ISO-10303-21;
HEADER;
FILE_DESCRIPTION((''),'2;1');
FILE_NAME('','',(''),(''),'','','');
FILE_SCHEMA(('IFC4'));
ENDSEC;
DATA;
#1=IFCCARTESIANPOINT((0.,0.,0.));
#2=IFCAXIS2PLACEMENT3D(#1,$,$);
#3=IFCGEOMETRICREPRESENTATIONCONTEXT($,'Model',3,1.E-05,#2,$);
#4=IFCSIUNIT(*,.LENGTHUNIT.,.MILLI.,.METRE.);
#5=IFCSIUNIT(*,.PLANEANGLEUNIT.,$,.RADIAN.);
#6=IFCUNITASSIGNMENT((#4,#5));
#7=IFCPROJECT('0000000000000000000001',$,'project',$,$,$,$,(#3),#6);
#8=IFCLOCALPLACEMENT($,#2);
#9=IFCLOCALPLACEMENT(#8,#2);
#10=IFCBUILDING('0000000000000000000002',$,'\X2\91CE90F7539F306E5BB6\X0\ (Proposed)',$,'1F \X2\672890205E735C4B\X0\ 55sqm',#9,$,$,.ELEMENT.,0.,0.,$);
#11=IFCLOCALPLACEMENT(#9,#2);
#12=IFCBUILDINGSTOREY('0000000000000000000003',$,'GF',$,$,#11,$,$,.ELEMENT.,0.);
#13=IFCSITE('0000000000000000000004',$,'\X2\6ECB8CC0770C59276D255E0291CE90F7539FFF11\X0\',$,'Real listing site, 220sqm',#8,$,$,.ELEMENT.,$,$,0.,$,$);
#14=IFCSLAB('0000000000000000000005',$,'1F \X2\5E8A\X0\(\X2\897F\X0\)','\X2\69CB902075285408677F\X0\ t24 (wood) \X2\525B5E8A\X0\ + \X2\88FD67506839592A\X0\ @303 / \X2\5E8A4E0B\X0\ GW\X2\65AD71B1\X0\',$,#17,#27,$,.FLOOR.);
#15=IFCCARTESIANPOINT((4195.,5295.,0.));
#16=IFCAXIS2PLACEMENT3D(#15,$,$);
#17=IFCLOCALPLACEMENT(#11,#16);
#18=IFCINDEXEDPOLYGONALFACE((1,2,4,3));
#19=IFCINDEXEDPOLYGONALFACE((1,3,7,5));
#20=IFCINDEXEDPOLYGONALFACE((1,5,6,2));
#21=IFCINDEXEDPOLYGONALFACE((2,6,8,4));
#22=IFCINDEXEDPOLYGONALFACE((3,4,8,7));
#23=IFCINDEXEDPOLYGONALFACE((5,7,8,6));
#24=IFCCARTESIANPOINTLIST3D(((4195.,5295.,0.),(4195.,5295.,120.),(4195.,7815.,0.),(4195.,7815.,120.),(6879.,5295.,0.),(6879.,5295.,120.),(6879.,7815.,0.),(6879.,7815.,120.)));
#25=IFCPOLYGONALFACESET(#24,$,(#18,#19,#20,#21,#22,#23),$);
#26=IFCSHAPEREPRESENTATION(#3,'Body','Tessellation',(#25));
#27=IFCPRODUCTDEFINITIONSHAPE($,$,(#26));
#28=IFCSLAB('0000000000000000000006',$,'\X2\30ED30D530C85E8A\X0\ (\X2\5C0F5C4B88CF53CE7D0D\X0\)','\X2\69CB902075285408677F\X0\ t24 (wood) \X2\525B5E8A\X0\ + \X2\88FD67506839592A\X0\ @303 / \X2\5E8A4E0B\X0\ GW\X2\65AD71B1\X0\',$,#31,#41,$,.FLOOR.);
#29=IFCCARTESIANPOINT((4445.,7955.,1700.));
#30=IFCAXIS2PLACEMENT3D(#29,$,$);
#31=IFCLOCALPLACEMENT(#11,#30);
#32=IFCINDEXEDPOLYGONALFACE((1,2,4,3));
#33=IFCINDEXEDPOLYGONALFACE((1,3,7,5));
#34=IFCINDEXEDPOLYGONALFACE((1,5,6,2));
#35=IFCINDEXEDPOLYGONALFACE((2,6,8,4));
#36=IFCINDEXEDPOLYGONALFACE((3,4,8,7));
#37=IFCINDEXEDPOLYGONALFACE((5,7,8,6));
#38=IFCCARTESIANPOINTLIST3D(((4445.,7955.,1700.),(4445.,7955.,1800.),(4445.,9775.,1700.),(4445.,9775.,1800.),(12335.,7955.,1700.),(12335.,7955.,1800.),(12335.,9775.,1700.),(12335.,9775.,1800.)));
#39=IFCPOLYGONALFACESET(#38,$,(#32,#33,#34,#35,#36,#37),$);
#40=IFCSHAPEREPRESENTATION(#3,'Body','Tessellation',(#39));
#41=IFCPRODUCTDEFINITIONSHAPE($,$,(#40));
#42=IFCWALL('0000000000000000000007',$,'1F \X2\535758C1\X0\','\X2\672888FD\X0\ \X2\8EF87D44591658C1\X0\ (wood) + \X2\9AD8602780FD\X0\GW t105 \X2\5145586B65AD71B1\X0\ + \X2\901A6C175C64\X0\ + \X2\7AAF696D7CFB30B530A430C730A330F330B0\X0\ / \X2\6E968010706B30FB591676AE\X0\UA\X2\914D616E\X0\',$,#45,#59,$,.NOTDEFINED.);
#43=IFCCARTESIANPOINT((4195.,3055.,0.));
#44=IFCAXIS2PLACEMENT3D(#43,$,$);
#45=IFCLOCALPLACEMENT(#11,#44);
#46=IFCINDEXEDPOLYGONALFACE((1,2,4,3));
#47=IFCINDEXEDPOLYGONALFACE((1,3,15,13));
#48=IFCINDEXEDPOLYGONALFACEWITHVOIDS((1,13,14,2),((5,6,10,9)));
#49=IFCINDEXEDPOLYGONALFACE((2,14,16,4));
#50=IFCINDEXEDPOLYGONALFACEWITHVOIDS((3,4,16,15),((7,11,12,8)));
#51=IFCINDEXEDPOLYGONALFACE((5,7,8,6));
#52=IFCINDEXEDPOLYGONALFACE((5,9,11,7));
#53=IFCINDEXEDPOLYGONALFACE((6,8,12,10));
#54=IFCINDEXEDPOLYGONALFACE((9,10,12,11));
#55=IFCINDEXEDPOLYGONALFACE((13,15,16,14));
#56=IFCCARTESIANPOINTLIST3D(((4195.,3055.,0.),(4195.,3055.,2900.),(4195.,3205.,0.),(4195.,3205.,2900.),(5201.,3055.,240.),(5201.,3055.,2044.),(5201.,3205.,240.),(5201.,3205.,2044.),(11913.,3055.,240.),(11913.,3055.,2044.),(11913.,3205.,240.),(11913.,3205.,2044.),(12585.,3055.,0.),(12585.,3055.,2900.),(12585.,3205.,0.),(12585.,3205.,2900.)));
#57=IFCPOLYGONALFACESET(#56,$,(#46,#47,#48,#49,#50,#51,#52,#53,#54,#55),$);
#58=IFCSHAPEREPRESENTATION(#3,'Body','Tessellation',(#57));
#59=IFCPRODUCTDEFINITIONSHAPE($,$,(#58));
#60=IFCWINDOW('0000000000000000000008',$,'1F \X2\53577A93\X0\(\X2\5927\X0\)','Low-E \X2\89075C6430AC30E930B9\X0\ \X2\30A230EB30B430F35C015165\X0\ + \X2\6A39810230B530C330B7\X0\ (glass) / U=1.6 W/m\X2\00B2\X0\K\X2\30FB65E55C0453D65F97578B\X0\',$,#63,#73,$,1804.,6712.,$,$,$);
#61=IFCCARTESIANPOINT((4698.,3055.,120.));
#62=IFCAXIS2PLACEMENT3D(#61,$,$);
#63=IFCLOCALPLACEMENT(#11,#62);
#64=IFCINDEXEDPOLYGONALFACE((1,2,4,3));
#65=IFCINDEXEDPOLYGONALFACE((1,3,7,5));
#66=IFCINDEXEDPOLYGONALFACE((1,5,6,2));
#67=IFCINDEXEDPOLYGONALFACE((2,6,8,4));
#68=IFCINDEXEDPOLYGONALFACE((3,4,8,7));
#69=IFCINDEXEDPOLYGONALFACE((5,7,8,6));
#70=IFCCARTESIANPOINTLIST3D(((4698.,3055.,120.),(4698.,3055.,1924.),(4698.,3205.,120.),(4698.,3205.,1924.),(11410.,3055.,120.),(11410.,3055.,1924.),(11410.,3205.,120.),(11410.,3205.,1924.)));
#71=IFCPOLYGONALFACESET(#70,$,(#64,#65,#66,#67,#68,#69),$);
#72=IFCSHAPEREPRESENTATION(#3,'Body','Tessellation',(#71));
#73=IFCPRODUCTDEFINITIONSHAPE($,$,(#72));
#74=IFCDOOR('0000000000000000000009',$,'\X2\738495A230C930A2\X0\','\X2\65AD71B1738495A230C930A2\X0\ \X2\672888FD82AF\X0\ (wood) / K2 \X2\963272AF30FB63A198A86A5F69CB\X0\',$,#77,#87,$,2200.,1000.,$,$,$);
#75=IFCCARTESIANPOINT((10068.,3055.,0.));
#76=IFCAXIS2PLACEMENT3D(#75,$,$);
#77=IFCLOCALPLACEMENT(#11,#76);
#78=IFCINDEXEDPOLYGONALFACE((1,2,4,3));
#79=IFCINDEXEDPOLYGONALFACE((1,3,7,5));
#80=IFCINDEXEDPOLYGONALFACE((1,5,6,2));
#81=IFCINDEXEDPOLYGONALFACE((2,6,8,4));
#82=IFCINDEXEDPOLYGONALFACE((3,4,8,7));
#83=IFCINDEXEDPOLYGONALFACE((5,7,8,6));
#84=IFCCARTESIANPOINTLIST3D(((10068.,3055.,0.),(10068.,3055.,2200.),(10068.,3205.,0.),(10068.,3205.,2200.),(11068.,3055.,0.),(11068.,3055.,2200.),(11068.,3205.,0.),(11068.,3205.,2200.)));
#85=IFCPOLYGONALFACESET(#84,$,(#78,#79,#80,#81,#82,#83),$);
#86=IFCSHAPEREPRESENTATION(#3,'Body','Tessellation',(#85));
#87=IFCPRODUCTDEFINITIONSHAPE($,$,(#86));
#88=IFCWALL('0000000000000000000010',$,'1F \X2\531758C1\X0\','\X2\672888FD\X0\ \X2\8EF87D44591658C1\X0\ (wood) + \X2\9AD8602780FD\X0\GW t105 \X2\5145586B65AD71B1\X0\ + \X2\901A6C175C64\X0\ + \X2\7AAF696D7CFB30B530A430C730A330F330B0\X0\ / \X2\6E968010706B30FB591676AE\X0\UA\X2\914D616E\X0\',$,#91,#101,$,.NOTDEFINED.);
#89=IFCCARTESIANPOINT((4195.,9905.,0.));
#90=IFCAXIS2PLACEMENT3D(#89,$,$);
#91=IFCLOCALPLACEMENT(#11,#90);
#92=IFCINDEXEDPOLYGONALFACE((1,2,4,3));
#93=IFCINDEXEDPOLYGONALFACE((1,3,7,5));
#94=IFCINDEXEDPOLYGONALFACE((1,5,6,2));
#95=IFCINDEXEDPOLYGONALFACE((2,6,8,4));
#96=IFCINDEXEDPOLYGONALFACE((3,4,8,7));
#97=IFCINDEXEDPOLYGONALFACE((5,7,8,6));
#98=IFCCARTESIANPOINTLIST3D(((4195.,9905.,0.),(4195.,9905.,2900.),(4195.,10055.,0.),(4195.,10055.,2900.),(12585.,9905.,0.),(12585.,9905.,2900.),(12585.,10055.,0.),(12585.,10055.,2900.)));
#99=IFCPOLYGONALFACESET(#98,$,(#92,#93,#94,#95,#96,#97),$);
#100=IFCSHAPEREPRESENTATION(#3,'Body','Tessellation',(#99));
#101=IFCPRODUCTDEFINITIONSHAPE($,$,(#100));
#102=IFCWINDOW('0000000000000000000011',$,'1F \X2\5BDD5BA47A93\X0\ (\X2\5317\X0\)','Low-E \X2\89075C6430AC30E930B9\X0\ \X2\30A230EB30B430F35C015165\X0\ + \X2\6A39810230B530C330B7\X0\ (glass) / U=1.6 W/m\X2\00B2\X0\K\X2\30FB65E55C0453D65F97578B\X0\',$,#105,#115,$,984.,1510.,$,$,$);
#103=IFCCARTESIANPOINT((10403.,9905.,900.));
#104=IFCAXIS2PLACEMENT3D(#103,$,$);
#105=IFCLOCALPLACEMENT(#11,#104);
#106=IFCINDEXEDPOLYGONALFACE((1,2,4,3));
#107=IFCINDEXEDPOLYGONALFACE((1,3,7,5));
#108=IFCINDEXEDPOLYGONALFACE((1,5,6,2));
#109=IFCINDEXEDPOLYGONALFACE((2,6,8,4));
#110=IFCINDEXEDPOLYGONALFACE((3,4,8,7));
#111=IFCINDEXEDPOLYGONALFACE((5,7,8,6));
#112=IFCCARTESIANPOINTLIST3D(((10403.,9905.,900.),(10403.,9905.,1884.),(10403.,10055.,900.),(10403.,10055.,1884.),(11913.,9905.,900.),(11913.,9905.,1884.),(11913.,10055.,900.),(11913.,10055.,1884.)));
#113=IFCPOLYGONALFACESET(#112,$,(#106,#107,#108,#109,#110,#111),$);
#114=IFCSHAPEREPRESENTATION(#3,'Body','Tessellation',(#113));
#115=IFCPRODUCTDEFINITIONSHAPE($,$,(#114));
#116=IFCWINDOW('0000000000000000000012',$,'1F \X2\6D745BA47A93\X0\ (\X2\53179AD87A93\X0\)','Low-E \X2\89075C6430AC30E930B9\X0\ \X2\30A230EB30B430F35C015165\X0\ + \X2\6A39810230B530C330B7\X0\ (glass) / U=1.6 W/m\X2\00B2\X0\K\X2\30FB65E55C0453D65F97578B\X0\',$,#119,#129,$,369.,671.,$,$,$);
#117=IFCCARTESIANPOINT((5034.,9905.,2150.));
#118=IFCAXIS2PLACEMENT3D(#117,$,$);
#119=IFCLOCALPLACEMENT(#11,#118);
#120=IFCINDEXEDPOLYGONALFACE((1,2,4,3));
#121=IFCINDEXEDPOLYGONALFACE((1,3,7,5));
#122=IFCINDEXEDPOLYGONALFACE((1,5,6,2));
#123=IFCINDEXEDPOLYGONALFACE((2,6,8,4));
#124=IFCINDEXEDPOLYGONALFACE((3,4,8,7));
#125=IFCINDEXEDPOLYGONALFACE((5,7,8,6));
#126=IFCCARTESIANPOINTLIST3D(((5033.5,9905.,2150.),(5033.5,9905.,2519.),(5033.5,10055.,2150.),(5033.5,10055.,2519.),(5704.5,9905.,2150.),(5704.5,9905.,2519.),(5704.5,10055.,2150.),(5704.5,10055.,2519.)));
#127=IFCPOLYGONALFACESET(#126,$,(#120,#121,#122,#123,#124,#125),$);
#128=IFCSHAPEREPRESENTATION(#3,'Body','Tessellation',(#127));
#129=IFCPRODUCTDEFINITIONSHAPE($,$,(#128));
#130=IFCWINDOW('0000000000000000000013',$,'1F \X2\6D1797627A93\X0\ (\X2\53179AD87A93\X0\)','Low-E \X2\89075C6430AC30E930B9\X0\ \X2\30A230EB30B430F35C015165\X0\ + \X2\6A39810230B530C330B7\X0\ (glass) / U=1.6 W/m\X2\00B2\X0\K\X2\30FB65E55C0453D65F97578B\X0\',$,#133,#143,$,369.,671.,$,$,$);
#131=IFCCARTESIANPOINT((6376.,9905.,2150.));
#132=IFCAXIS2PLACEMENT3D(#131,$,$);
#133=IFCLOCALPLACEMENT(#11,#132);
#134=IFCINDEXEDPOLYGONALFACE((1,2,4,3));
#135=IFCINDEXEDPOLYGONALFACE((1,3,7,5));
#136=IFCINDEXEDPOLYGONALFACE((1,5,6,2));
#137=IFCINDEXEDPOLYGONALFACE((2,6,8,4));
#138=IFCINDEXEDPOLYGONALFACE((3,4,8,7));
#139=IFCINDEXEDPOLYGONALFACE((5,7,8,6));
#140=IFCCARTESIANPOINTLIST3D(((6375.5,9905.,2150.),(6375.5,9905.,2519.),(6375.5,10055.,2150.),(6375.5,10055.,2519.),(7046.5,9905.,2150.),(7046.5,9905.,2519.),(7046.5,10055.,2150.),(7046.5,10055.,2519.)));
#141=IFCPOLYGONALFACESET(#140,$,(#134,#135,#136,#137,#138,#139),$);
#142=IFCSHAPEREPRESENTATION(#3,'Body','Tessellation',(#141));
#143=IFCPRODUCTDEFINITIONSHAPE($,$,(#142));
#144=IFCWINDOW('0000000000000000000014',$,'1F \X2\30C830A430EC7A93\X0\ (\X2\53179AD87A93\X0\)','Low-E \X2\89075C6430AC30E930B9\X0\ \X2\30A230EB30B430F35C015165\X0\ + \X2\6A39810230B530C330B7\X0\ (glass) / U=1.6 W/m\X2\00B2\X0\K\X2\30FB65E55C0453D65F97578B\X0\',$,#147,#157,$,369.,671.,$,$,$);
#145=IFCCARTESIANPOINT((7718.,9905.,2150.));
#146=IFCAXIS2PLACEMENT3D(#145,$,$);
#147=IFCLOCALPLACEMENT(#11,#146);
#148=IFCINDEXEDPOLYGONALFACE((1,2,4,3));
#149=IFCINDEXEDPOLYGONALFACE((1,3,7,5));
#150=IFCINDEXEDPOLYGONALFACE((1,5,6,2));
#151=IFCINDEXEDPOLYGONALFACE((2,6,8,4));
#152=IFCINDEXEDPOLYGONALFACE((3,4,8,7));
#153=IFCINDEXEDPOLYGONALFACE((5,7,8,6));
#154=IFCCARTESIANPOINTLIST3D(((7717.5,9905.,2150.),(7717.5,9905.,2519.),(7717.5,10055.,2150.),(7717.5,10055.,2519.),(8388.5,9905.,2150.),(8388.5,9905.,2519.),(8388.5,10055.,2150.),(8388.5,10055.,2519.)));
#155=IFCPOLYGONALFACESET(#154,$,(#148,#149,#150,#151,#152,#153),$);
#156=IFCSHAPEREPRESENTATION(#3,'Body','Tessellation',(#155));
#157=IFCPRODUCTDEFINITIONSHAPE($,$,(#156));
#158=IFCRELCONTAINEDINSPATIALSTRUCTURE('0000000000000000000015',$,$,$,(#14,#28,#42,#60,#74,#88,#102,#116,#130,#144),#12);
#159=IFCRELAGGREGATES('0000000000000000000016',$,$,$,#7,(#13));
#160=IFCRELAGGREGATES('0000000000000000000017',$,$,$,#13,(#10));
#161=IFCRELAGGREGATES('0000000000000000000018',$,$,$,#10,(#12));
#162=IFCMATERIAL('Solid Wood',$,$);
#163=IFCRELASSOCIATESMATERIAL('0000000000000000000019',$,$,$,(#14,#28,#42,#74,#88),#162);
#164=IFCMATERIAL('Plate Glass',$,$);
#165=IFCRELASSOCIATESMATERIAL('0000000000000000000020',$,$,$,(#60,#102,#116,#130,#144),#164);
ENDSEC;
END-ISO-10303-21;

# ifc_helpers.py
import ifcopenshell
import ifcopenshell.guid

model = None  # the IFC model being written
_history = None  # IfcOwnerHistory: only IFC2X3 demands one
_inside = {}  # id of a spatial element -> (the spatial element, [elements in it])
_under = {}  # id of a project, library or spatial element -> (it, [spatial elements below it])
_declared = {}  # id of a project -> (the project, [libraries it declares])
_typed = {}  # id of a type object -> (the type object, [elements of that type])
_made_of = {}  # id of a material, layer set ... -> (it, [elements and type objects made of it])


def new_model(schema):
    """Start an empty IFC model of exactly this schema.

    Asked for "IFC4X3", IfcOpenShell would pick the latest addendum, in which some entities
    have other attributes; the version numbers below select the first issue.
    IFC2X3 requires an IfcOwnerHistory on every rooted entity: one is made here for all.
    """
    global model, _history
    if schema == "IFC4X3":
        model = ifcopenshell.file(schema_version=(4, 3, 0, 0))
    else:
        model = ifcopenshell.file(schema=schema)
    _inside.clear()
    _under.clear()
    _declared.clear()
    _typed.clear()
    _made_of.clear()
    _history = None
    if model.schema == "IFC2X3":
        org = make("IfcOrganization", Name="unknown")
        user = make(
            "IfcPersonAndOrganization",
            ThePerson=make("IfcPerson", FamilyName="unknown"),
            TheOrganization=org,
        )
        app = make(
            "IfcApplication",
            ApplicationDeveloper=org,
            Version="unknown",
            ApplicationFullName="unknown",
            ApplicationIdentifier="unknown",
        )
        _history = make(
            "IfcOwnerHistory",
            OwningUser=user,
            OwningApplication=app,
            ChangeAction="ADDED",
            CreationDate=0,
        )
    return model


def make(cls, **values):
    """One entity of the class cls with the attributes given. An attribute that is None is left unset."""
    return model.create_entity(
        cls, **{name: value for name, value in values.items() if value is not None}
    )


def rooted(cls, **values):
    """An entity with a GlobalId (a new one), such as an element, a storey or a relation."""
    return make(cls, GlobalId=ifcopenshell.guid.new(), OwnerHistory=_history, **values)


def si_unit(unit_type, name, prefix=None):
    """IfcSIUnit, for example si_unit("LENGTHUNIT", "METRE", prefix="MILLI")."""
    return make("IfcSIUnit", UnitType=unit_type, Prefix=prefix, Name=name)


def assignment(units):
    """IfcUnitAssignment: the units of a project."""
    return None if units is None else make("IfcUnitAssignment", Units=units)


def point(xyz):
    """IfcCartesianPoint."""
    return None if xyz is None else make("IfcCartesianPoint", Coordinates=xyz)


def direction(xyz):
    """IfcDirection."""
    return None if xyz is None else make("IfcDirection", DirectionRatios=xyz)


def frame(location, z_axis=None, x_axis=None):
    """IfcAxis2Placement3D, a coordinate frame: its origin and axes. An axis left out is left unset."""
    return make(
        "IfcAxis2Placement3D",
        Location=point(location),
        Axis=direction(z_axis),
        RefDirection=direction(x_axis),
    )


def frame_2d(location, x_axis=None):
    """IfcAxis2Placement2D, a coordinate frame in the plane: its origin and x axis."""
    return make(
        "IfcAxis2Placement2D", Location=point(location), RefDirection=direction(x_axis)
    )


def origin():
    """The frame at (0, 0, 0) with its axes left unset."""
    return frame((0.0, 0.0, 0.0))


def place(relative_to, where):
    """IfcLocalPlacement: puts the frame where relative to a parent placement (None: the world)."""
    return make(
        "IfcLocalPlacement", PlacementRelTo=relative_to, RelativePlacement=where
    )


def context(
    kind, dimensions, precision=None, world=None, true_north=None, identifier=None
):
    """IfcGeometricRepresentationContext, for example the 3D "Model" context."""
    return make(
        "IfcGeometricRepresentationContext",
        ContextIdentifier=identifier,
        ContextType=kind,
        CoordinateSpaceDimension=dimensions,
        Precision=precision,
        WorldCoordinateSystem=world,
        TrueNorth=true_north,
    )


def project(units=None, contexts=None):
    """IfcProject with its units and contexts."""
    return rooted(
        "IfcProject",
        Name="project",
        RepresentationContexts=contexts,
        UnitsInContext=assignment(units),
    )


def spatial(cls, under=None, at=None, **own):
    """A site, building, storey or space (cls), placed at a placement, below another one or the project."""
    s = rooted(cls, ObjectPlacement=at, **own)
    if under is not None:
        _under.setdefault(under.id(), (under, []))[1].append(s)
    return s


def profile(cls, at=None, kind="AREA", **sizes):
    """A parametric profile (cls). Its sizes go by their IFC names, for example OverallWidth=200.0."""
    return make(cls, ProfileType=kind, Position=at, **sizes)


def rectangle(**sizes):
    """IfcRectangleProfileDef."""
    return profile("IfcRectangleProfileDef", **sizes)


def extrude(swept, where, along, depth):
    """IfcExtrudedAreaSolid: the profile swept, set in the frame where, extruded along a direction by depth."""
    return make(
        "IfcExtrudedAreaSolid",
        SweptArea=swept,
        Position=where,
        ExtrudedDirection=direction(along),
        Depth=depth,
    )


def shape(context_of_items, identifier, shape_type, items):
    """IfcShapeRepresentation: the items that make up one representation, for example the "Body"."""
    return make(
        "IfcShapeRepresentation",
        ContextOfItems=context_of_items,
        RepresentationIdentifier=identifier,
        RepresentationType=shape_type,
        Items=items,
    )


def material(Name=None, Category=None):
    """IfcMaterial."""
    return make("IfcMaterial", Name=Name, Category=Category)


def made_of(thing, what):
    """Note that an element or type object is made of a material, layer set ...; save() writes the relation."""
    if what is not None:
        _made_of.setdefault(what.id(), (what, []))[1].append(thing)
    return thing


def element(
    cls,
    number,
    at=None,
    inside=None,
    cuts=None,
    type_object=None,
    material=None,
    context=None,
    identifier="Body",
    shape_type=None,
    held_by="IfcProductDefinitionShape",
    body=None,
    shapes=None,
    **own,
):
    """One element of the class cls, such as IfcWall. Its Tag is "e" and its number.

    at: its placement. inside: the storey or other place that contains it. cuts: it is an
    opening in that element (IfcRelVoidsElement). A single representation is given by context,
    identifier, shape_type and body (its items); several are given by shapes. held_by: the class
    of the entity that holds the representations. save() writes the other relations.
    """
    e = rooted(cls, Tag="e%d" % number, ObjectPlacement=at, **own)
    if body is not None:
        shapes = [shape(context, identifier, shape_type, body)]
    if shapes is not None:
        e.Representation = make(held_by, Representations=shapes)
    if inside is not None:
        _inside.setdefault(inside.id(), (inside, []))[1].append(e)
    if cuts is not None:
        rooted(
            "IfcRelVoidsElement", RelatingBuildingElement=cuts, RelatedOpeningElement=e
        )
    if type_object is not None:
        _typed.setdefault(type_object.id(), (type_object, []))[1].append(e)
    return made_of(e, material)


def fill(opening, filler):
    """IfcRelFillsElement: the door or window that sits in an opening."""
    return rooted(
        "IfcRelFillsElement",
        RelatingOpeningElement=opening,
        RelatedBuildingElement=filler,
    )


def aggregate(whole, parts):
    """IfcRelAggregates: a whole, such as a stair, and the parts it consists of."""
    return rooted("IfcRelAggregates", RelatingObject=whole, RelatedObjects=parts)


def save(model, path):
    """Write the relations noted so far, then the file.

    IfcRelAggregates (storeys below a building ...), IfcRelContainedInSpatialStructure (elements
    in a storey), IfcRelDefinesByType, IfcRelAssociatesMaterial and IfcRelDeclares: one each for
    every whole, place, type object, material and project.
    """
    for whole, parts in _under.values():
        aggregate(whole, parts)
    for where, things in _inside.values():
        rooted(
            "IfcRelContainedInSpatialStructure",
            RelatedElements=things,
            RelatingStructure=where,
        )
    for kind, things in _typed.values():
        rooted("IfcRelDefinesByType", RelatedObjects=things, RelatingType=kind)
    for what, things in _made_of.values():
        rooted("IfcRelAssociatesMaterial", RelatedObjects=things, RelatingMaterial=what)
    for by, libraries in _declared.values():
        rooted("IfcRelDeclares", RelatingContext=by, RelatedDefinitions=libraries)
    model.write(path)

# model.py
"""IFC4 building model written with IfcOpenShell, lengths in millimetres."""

from ifc_helpers import new_model, si_unit, frame, frame_2d, origin, place, context, project, spatial, rectangle, extrude, material, element, fill, save


model = new_model("IFC4")

# Units and contexts
model_context = context("Model", 3, precision=1e-05, world=origin())
ifc_project = project(units=[si_unit("LENGTHUNIT", "METRE", prefix="MILLI"), si_unit("PLANEANGLEUNIT", "RADIAN")], contexts=[model_context])

# Site, building, storey
site_placement = place(None, origin())
site = spatial("IfcSite", under=ifc_project, at=site_placement, Name="滋賀県大津市野郷原１", ObjectType="Real listing site, 220sqm", CompositionType="ELEMENT", RefElevation=0.0)
building_placement = place(site_placement, origin())
building = spatial("IfcBuilding", under=site, at=building_placement, Name="野郷原の家 (Proposed)", ObjectType="1F 木造平屋 55sqm", CompositionType="ELEMENT", ElevationOfRefHeight=0.0, ElevationOfTerrain=0.0)
storey_placement = place(building_placement, origin())
storey = spatial("IfcBuildingStorey", under=building, at=storey_placement, Name="GF", CompositionType="ELEMENT", Elevation=0.0)

# Slabs
ifc_material_1 = material(Name="Solid Wood")
slab_1_placement = place(storey_placement, frame((4195.0, 5295.0, 0.0)))
element("IfcSlab", 1, at=slab_1_placement, inside=storey, material=ifc_material_1, Name="1F 床(西)", Description="構造用合板 t24 (wood) 剛床 + 製材根太 @303 / 床下 GW断熱", PredefinedType="FLOOR", context=model_context, shape_type="SweptSolid", body=[
    extrude(rectangle(XDim=2684.0, YDim=2520.0, at=frame_2d((1342.0, 1260.0))), frame((4195.0, 5295.0, 0.0)), (0.0, 0.0, 1.0), 120.0),
])
slab_2_placement = place(storey_placement, frame((4445.0, 7955.0, 1700.0)))
element("IfcSlab", 2, at=slab_2_placement, inside=storey, material=ifc_material_1, Name="ロフト床 (小屋裏収納)", Description="構造用合板 t24 (wood) 剛床 + 製材根太 @303 / 床下 GW断熱", PredefinedType="FLOOR", context=model_context, shape_type="SweptSolid", body=[
    extrude(rectangle(XDim=7890.0, YDim=1820.0, at=frame_2d((3945.0, 910.0))), frame((4445.0, 7955.0, 1700.0)), (0.0, 0.0, 1.0), 100.0),
])

# Wall, openings, window, door
wall_1_placement = place(storey_placement, frame((4195.0, 3055.0, 0.0)))
wall_1 = element("IfcWall", 3, at=wall_1_placement, inside=storey, material=ifc_material_1, Name="1F 南壁", Description="木製 軸組外壁 (wood) + 高性能GW t105 充填断熱 + 通気層 + 窯業系サイディング / 準耐火・外皮UA配慮", PredefinedType="NOTDEFINED", context=model_context, shape_type="SweptSolid", body=[
    extrude(rectangle(XDim=8390.0, YDim=150.0, at=frame_2d((4195.0, 75.0))), frame((4195.0, 3055.0, 0.0)), (0.0, 0.0, 1.0), 2900.0),
])
opening_1_placement = place(storey_placement, frame((4698.0, 3055.0, 120.0)))
opening_1 = element("IfcOpeningElement", 4, at=opening_1_placement, cuts=wall_1, PredefinedType="NOTDEFINED", context=model_context, shape_type="SweptSolid", body=[
    extrude(rectangle(XDim=6712.0, YDim=150.0, at=frame_2d((3356.0, 75.0))), frame((4698.0, 3055.0, 120.0)), (0.0, 0.0, 1.0), 1804.0),
])
opening_2_placement = place(storey_placement, frame((10068.0, 3055.0, 0.0)))
opening_2 = element("IfcOpeningElement", 5, at=opening_2_placement, cuts=wall_1, PredefinedType="NOTDEFINED", context=model_context, shape_type="SweptSolid", body=[
    extrude(rectangle(XDim=1000.0, YDim=150.0, at=frame_2d((500.0, 75.0))), frame((10068.0, 3055.0, 0.0)), (0.0, 0.0, 1.0), 2200.0),
])
ifc_material_2 = material(Name="Plate Glass")
window_1_placement = place(storey_placement, frame((4698.0, 3055.0, 120.0)))
window_1 = element("IfcWindow", 6, at=window_1_placement, inside=storey, material=ifc_material_2, Name="1F 南窓(大)", Description="Low-E 複層ガラス アルゴン封入 + 樹脂サッシ (glass) / U=1.6 W/m²K・日射取得型", OverallHeight=1804.0, OverallWidth=6712.0, context=model_context, shape_type="SweptSolid", body=[
    extrude(rectangle(XDim=6712.0, YDim=150.0, at=frame_2d((3356.0, 75.0))), frame((4698.0, 3055.0, 120.0)), (0.0, 0.0, 1.0), 1804.0),
])
fill(opening_1, window_1)
door_1_placement = place(storey_placement, frame((10068.0, 3055.0, 0.0)))
door_1 = element("IfcDoor", 7, at=door_1_placement, inside=storey, material=ifc_material_1, Name="玄関ドア", Description="断熱玄関ドア 木製芯 (wood) / K2 防犯・採風機構", OverallHeight=2200.0, OverallWidth=1000.0, context=model_context, shape_type="SweptSolid", body=[
    extrude(rectangle(XDim=1000.0, YDim=150.0, at=frame_2d((500.0, 75.0))), frame((10068.0, 3055.0, 0.0)), (0.0, 0.0, 1.0), 2200.0),
])
fill(opening_2, door_1)

# Wall, openings, windows
wall_2_placement = place(storey_placement, frame((4195.0, 9905.0, 0.0)))
wall_2 = element("IfcWall", 8, at=wall_2_placement, inside=storey, material=ifc_material_1, Name="1F 北壁", Description="木製 軸組外壁 (wood) + 高性能GW t105 充填断熱 + 通気層 + 窯業系サイディング / 準耐火・外皮UA配慮", PredefinedType="NOTDEFINED", context=model_context, shape_type="SweptSolid", body=[
    extrude(rectangle(XDim=8390.0, YDim=150.0, at=frame_2d((4195.0, 75.0))), frame((4195.0, 9905.0, 0.0)), (0.0, 0.0, 1.0), 2900.0),
])
opening_3_placement = place(storey_placement, frame((10403.0, 9905.0, 900.0)))
opening_3 = element("IfcOpeningElement", 9, at=opening_3_placement, cuts=wall_2, PredefinedType="NOTDEFINED", context=model_context, shape_type="SweptSolid", body=[
    extrude(rectangle(XDim=1510.0, YDim=150.0, at=frame_2d((755.0, 75.0))), frame((10403.0, 9905.0, 900.0)), (0.0, 0.0, 1.0), 984.0),
])
opening_4_placement = place(storey_placement, frame((5034.0, 9905.0, 2150.0)))
opening_4 = element("IfcOpeningElement", 10, at=opening_4_placement, cuts=wall_2, PredefinedType="NOTDEFINED", context=model_context, shape_type="SweptSolid", body=[
    extrude(rectangle(XDim=671.0, YDim=150.0, at=frame_2d((335.0, 75.0))), frame((5034.0, 9905.0, 2150.0)), (0.0, 0.0, 1.0), 369.0),
])
opening_5_placement = place(storey_placement, frame((6376.0, 9905.0, 2150.0)))
opening_5 = element("IfcOpeningElement", 11, at=opening_5_placement, cuts=wall_2, PredefinedType="NOTDEFINED", context=model_context, shape_type="SweptSolid", body=[
    extrude(rectangle(XDim=671.0, YDim=150.0, at=frame_2d((335.0, 75.0))), frame((6376.0, 9905.0, 2150.0)), (0.0, 0.0, 1.0), 369.0),
])
opening_6_placement = place(storey_placement, frame((7718.0, 9905.0, 2150.0)))
opening_6 = element("IfcOpeningElement", 12, at=opening_6_placement, cuts=wall_2, PredefinedType="NOTDEFINED", context=model_context, shape_type="SweptSolid", body=[
    extrude(rectangle(XDim=671.0, YDim=150.0, at=frame_2d((335.0, 75.0))), frame((7718.0, 9905.0, 2150.0)), (0.0, 0.0, 1.0), 369.0),
])
window_2_placement = place(storey_placement, frame((10403.0, 9905.0, 900.0)))
window_2 = element("IfcWindow", 13, at=window_2_placement, inside=storey, material=ifc_material_2, Name="1F 寝室窓 (北)", Description="Low-E 複層ガラス アルゴン封入 + 樹脂サッシ (glass) / U=1.6 W/m²K・日射取得型", OverallHeight=984.0, OverallWidth=1510.0, context=model_context, shape_type="SweptSolid", body=[
    extrude(rectangle(XDim=1510.0, YDim=150.0, at=frame_2d((755.0, 75.0))), frame((10403.0, 9905.0, 900.0)), (0.0, 0.0, 1.0), 984.0),
])
fill(opening_3, window_2)
window_3_placement = place(storey_placement, frame((5034.0, 9905.0, 2150.0)))
window_3 = element("IfcWindow", 14, at=window_3_placement, inside=storey, material=ifc_material_2, Name="1F 浴室窓 (北高窓)", Description="Low-E 複層ガラス アルゴン封入 + 樹脂サッシ (glass) / U=1.6 W/m²K・日射取得型", OverallHeight=369.0, OverallWidth=671.0, context=model_context, shape_type="SweptSolid", body=[
    extrude(rectangle(XDim=671.0, YDim=150.0, at=frame_2d((335.0, 75.0))), frame((5034.0, 9905.0, 2150.0)), (0.0, 0.0, 1.0), 369.0),
])
fill(opening_4, window_3)
window_4_placement = place(storey_placement, frame((6376.0, 9905.0, 2150.0)))
window_4 = element("IfcWindow", 15, at=window_4_placement, inside=storey, material=ifc_material_2, Name="1F 洗面窓 (北高窓)", Description="Low-E 複層ガラス アルゴン封入 + 樹脂サッシ (glass) / U=1.6 W/m²K・日射取得型", OverallHeight=369.0, OverallWidth=671.0, context=model_context, shape_type="SweptSolid", body=[
    extrude(rectangle(XDim=671.0, YDim=150.0, at=frame_2d((335.0, 75.0))), frame((6376.0, 9905.0, 2150.0)), (0.0, 0.0, 1.0), 369.0),
])
fill(opening_5, window_4)
window_5_placement = place(storey_placement, frame((7718.0, 9905.0, 2150.0)))
window_5 = element("IfcWindow", 16, at=window_5_placement, inside=storey, material=ifc_material_2, Name="1F トイレ窓 (北高窓)", Description="Low-E 複層ガラス アルゴン封入 + 樹脂サッシ (glass) / U=1.6 W/m²K・日射取得型", OverallHeight=369.0, OverallWidth=671.0, context=model_context, shape_type="SweptSolid", body=[
    extrude(rectangle(XDim=671.0, YDim=150.0, at=frame_2d((335.0, 75.0))), frame((7718.0, 9905.0, 2150.0)), (0.0, 0.0, 1.0), 369.0),
])
fill(opening_6, window_5)

save(model, "model.ifc")
